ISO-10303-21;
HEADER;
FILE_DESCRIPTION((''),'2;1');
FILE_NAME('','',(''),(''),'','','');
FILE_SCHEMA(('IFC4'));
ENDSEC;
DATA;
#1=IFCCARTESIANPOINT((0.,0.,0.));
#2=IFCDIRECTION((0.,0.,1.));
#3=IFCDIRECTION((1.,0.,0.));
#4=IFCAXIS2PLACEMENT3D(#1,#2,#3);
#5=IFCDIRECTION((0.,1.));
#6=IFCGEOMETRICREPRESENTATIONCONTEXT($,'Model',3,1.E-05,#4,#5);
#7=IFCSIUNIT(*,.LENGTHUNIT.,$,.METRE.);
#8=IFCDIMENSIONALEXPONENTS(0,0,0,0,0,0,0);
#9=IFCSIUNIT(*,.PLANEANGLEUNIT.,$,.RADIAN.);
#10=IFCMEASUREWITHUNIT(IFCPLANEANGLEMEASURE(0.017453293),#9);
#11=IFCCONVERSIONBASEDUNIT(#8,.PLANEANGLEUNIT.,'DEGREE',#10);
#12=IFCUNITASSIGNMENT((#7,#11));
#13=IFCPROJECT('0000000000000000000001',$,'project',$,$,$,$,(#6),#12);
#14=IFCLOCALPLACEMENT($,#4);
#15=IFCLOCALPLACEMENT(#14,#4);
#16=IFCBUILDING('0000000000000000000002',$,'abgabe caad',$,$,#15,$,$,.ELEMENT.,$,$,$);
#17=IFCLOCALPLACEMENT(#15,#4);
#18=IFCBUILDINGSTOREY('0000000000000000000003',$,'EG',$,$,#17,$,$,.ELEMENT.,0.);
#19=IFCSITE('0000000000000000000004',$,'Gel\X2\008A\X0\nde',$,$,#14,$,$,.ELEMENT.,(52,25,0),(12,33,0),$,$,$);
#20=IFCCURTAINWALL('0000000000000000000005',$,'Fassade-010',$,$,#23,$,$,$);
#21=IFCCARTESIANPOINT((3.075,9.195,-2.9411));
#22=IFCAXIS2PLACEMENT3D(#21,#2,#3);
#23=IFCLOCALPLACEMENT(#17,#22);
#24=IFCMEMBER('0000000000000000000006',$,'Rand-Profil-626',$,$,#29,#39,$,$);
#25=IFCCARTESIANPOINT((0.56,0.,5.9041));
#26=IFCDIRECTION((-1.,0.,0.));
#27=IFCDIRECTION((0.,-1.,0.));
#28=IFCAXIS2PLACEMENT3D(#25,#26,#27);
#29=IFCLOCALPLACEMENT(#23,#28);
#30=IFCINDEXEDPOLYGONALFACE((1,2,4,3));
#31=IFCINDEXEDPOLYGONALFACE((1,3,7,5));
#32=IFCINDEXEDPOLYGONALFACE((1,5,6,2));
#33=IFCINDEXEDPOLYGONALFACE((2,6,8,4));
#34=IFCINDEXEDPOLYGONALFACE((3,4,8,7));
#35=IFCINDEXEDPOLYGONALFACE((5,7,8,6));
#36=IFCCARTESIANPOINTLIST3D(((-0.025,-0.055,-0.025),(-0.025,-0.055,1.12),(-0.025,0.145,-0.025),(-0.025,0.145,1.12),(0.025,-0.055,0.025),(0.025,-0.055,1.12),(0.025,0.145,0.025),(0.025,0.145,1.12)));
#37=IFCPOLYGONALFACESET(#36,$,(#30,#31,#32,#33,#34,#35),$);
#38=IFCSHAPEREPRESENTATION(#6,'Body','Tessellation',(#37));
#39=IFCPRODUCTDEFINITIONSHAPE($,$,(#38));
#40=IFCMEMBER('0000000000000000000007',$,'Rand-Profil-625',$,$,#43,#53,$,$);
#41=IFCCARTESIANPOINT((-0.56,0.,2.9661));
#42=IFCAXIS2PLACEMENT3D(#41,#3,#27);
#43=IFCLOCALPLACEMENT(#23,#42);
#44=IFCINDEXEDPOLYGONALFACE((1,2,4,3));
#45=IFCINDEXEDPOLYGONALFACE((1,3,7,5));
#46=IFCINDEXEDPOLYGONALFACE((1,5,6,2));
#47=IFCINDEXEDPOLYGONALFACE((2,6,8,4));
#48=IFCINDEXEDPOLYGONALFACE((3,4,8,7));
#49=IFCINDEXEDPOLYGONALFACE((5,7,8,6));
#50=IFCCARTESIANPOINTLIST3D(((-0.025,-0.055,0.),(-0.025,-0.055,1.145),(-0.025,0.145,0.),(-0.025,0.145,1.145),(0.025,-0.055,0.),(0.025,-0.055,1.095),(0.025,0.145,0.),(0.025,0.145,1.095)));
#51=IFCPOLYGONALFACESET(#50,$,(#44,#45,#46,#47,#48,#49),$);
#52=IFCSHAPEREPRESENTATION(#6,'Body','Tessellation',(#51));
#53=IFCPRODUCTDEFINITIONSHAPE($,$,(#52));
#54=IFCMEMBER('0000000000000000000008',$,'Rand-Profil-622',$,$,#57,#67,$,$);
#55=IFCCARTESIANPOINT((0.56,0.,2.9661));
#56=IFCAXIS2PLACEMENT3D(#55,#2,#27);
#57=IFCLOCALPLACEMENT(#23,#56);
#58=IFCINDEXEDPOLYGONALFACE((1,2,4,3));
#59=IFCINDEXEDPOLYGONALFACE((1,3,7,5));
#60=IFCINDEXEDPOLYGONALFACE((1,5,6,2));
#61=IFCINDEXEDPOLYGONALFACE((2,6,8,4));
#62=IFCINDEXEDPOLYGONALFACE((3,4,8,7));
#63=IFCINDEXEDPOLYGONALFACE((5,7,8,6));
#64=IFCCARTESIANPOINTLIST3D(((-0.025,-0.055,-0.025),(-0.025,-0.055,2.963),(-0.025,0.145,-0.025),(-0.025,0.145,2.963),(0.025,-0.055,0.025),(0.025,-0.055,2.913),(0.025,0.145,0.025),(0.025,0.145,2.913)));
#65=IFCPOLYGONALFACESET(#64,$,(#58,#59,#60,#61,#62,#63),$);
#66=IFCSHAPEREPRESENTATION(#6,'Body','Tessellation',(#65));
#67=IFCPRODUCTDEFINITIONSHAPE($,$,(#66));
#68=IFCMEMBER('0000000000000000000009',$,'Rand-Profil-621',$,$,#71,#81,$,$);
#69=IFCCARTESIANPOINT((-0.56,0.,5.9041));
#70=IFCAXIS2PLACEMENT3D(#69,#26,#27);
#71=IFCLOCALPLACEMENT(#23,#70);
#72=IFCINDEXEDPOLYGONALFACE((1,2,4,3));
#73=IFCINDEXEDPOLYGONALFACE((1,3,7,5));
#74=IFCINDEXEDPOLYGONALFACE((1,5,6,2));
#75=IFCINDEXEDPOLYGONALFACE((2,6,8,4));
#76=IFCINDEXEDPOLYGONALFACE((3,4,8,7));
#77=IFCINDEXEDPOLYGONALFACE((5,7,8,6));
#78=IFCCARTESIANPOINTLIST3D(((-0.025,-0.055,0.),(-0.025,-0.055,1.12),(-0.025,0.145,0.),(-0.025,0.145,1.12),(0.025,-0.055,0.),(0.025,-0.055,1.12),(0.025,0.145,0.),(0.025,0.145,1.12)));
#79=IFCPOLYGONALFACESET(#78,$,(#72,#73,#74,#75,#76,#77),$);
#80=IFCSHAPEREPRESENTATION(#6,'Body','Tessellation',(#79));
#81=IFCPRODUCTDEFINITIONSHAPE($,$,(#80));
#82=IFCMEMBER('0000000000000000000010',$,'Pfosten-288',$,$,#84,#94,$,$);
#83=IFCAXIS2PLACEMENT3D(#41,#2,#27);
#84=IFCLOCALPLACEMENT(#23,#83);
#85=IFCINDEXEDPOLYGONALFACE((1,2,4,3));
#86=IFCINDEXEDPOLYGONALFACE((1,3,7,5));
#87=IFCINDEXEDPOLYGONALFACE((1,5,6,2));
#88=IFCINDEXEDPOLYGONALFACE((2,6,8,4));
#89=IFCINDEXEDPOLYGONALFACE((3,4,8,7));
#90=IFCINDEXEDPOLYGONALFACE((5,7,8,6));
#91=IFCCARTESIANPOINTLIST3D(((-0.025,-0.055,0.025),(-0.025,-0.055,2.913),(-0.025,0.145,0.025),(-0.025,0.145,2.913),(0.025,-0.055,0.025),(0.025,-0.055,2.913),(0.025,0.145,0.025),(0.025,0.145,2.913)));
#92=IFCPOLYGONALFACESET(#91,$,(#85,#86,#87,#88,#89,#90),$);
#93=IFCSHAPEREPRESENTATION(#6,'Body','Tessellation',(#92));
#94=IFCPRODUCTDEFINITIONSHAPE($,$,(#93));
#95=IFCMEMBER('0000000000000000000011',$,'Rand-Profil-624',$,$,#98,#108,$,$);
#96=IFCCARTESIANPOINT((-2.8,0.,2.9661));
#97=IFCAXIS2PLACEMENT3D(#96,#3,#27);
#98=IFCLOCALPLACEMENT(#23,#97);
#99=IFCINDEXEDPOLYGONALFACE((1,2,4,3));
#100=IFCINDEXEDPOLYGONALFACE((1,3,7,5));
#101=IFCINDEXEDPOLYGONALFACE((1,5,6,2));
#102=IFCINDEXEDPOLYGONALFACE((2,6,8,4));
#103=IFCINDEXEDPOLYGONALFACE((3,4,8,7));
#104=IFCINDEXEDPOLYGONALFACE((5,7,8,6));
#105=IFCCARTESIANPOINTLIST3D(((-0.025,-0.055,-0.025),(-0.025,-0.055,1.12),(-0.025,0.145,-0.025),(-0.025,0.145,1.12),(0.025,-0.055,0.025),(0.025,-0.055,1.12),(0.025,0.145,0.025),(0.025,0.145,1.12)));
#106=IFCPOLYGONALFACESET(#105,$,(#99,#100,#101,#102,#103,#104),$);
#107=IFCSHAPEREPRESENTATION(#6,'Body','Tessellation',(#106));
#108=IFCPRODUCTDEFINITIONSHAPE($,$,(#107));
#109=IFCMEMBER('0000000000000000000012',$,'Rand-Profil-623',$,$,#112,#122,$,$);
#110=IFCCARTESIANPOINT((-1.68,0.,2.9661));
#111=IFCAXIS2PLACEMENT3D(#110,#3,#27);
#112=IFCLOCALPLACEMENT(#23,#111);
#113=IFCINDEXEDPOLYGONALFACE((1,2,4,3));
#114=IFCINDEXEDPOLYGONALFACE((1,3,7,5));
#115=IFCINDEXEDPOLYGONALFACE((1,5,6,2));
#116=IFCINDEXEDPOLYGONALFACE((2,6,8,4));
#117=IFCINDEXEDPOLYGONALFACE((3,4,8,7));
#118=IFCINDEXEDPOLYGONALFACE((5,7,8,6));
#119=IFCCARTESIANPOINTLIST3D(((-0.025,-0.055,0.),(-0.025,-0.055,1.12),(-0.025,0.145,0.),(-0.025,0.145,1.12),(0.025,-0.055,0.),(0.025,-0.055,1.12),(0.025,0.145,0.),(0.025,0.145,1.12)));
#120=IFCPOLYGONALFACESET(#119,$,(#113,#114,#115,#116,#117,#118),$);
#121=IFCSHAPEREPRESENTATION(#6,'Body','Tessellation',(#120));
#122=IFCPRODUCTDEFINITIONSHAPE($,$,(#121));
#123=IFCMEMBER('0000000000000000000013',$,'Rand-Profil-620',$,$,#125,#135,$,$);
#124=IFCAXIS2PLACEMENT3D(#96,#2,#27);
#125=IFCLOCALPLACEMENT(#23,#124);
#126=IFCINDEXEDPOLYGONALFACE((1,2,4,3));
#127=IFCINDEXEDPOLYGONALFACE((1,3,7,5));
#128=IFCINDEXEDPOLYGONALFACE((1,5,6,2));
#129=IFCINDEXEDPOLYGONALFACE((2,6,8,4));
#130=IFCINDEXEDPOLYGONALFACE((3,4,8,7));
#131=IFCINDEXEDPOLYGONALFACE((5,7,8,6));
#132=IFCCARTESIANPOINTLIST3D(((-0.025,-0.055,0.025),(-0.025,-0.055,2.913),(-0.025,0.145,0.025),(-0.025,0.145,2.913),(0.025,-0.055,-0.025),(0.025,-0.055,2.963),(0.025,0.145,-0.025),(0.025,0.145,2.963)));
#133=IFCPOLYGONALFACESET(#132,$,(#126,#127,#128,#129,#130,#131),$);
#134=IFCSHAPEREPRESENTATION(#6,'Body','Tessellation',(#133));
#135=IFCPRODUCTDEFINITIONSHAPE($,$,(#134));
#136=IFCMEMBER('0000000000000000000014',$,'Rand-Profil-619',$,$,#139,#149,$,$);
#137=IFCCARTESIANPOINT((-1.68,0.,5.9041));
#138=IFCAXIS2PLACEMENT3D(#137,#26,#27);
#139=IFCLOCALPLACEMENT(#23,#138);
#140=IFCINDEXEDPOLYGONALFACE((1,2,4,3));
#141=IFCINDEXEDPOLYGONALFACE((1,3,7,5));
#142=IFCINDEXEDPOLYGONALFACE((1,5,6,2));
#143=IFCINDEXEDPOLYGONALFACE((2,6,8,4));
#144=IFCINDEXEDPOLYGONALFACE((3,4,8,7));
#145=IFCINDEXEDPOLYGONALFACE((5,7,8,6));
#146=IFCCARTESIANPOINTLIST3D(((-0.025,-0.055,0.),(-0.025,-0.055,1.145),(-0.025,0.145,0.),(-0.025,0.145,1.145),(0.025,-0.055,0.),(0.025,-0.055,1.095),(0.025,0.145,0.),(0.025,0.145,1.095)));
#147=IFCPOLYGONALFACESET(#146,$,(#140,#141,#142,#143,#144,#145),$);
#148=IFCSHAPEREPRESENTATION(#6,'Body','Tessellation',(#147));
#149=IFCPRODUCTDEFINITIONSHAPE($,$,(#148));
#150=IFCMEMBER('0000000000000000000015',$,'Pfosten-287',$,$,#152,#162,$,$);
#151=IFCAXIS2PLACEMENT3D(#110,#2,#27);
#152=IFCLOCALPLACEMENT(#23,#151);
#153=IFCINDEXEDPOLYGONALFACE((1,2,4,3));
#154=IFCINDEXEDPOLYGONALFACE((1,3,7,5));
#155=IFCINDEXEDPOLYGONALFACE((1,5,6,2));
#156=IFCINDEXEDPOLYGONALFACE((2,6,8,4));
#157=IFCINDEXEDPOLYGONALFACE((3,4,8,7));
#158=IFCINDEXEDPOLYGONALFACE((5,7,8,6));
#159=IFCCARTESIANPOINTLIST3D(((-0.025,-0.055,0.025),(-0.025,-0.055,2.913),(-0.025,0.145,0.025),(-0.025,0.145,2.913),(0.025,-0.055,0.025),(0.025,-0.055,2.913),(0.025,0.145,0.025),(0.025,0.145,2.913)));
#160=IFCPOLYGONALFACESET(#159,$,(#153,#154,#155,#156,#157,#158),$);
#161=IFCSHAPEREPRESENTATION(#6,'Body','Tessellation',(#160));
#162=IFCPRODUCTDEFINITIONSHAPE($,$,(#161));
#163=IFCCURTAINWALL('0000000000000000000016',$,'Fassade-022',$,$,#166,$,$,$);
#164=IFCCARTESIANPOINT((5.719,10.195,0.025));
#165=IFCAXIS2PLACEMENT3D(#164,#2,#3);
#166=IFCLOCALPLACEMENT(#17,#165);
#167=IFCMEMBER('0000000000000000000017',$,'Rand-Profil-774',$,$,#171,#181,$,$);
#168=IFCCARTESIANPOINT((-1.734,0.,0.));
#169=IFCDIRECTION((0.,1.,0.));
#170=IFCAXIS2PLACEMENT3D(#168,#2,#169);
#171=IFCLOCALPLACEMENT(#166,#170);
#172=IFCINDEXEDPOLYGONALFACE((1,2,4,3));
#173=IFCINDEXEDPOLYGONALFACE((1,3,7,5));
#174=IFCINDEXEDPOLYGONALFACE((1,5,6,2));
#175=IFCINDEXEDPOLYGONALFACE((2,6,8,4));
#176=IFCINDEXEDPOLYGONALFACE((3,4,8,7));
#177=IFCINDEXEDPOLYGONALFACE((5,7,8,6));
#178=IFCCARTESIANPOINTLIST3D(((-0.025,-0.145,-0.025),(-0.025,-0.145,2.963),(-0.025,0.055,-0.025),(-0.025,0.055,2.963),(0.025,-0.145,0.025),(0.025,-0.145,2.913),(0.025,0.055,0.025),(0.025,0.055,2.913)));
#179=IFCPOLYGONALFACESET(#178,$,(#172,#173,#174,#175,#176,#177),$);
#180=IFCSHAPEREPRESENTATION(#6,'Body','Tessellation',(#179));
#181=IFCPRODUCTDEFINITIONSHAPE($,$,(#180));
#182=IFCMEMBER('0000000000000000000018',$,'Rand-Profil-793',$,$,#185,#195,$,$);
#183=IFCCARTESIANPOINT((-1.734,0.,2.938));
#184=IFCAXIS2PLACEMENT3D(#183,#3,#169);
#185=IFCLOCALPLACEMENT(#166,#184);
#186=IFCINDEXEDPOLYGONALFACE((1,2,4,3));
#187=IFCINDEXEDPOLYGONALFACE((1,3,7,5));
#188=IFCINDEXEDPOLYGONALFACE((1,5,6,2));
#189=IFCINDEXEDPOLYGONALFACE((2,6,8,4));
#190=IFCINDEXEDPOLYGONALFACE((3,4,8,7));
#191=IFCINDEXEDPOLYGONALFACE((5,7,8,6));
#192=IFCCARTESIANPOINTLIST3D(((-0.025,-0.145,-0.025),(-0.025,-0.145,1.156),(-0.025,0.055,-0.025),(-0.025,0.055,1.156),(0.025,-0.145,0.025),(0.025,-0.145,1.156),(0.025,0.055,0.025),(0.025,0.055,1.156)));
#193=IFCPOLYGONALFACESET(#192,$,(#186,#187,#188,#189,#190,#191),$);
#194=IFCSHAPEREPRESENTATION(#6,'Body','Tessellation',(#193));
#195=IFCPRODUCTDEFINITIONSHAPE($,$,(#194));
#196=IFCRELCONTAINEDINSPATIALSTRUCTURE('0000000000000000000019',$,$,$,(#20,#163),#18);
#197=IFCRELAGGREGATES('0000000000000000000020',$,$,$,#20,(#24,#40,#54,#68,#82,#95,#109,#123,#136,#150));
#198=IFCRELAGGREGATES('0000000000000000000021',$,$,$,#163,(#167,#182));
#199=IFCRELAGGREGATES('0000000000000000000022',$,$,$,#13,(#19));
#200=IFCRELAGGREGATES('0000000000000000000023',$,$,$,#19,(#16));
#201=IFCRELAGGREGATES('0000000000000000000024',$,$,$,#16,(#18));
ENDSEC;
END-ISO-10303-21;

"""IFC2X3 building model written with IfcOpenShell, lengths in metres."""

from ifc_helpers import new_model, entity, si_unit, converted_unit, direction, frame, origin_with_axes, place, context, project, spatial, polyline, outline, extrude, clip, halfspace, element, aggregate, save


model = new_model("IFC2X3")

# Units and contexts
model_context = context("Model", 3, precision=1e-05, world=origin_with_axes(), true_north=direction((0.0, 1.0)))
ifc_project = project(units=[si_unit("LENGTHUNIT", "METRE"), converted_unit("PLANEANGLEUNIT", "DEGREE", entity("IfcPlaneAngleMeasure", 0.017453293), si_unit("PLANEANGLEUNIT", "RADIAN"), dimensions=[0, 0, 0, 0, 0, 0, 0])], contexts=[model_context])

# Site, building, storey
site_placement = place(None, origin_with_axes())
site = spatial("IfcSite", under=ifc_project, at=site_placement, Name="Gel\u008ande", CompositionType="ELEMENT", RefLatitude=(52, 25, 0), RefLongitude=(12, 33, 0))
building_placement = place(site_placement, origin_with_axes())
building = spatial("IfcBuilding", under=site, at=building_placement, Name="abgabe caad", CompositionType="ELEMENT")
storey_placement = place(building_placement, origin_with_axes())
storey = spatial("IfcBuildingStorey", under=building, at=storey_placement, Name="EG", CompositionType="ELEMENT", Elevation=0.0)

# Curtain walls, members
curtain_wall_1_placement = place(storey_placement, frame((3.075, 9.195, -2.9411), z_axis=(0.0, 0.0, 1.0), x_axis=(1.0, 0.0, 0.0)))
curtain_wall_1 = element("IfcCurtainWall", 1, at=curtain_wall_1_placement, inside=storey, Name="Fassade-010")
member_1_placement = place(curtain_wall_1_placement, frame((0.56, 0.0, 5.9041), z_axis=(-1.0, 0.0, 0.0), x_axis=(0.0, -1.0, 0.0)))
member_1 = element("IfcMember", 2, at=member_1_placement, Name="Rand-Profil-626", context=model_context, shape_type="Clipping", body=[
    clip(extrude(outline(polyline([(-0.025, -0.145), (0.025, -0.145), (0.025, 0.055), (-0.025, 0.055), (-0.025, -0.145)])), frame((0.0, 0.0, -0.025), z_axis=(0.0, 0.0, 1.0), x_axis=(-1.0, 0.0, 0.0)), (0.0, 0.0, 1.0), 1.145), halfspace(frame((0.0, 0.0, 0.0), z_axis=(-0.707107, 0.0, 0.707107), x_axis=(-0.707107, 0.0, -0.707107)), True)),
])
member_2_placement = place(curtain_wall_1_placement, frame((-0.56, 0.0, 2.9661), z_axis=(1.0, 0.0, 0.0), x_axis=(0.0, -1.0, 0.0)))
member_2 = element("IfcMember", 3, at=member_2_placement, Name="Rand-Profil-625", context=model_context, shape_type="Clipping", body=[
    clip(extrude(outline(polyline([(0.025, 0.145), (-0.025, 0.145), (-0.025, -0.055), (0.025, -0.055), (0.025, 0.145)])), origin_with_axes(), (0.0, 0.0, 1.0), 1.145), halfspace(frame((0.56, 0.0, 0.56), z_axis=(-0.707107, 0.0, -0.707107), x_axis=(0.707107, 0.0, -0.707107)), True)),
])
member_3_placement = place(curtain_wall_1_placement, frame((0.56, 0.0, 2.9661), z_axis=(0.0, 0.0, 1.0), x_axis=(0.0, -1.0, 0.0)))
member_3 = element("IfcMember", 4, at=member_3_placement, Name="Rand-Profil-622", context=model_context, shape_type="Clipping", body=[
    clip(clip(extrude(outline(polyline([(0.145, -0.025), (0.145, 0.025), (-0.055, 0.025), (-0.055, -0.025), (0.145, -0.025)])), frame((0.0, 0.0, -0.025), z_axis=(0.0, 0.0, 1.0), x_axis=(0.0, 1.0, 0.0)), (0.0, 0.0, 1.0), 2.988), halfspace(frame((0.0, 0.0, 0.0), z_axis=(-0.707107, 0.0, 0.707107), x_axis=(-0.707107, 0.0, -0.707107)), True)), halfspace(frame((1.469, 0.0, 1.469), z_axis=(-0.707107, 0.0, -0.707107), x_axis=(0.707107, 0.0, -0.707107)), True)),
])
member_4_placement = place(curtain_wall_1_placement, frame((-0.56, 0.0, 5.9041), z_axis=(-1.0, 0.0, 0.0), x_axis=(0.0, -1.0, 0.0)))
member_4 = element("IfcMember", 5, at=member_4_placement, Name="Rand-Profil-621", context=model_context, shape_type="SweptSolid", body=[
    extrude(outline(polyline([(-0.025, -0.145), (0.025, -0.145), (0.025, 0.055), (-0.025, 0.055), (-0.025, -0.145)])), frame((0.0, 0.0, 0.0), z_axis=(0.0, 0.0, 1.0), x_axis=(-1.0, 0.0, 0.0)), (0.0, 0.0, 1.0), 1.12),
])
member_5_placement = place(curtain_wall_1_placement, frame((-0.56, 0.0, 2.9661), z_axis=(0.0, 0.0, 1.0), x_axis=(0.0, -1.0, 0.0)))
member_5 = element("IfcMember", 6, at=member_5_placement, Name="Pfosten-288", context=model_context, shape_type="SweptSolid", body=[
    extrude(outline(polyline([(0.145, -0.025), (0.145, 0.025), (-0.055, 0.025), (-0.055, -0.025), (0.145, -0.025)])), frame((0.0, 0.0, 0.025), z_axis=(0.0, 0.0, 1.0), x_axis=(0.0, 1.0, 0.0)), (0.0, 0.0, 1.0), 2.888),
])
member_6_placement = place(curtain_wall_1_placement, frame((-2.8, 0.0, 2.9661), z_axis=(1.0, 0.0, 0.0), x_axis=(0.0, -1.0, 0.0)))
member_6 = element("IfcMember", 7, at=member_6_placement, Name="Rand-Profil-624", context=model_context, shape_type="Clipping", body=[
    clip(extrude(outline(polyline([(0.025, 0.145), (-0.025, 0.145), (-0.025, -0.055), (0.025, -0.055), (0.025, 0.145)])), frame((0.0, 0.0, -0.025), z_axis=(0.0, 0.0, 1.0), x_axis=(1.0, 0.0, 0.0)), (0.0, 0.0, 1.0), 1.145), halfspace(frame((0.0, 0.0, 0.0), z_axis=(-0.707107, 0.0, 0.707107), x_axis=(-0.707107, 0.0, -0.707107)), True)),
])
member_7_placement = place(curtain_wall_1_placement, frame((-1.68, 0.0, 2.9661), z_axis=(1.0, 0.0, 0.0), x_axis=(0.0, -1.0, 0.0)))
member_7 = element("IfcMember", 8, at=member_7_placement, Name="Rand-Profil-623", context=model_context, shape_type="SweptSolid", body=[
    extrude(outline(polyline([(0.025, 0.145), (-0.025, 0.145), (-0.025, -0.055), (0.025, -0.055), (0.025, 0.145)])), origin_with_axes(), (0.0, 0.0, 1.0), 1.12),
])
member_8_placement = place(curtain_wall_1_placement, frame((-2.8, 0.0, 2.9661), z_axis=(0.0, 0.0, 1.0), x_axis=(0.0, -1.0, 0.0)))
member_8 = element("IfcMember", 9, at=member_8_placement, Name="Rand-Profil-620", context=model_context, shape_type="Clipping", body=[
    clip(clip(extrude(outline(polyline([(0.145, -0.025), (0.145, 0.025), (-0.055, 0.025), (-0.055, -0.025), (0.145, -0.025)])), frame((0.0, 0.0, -0.025), z_axis=(0.0, 0.0, 1.0), x_axis=(0.0, 1.0, 0.0)), (0.0, 0.0, 1.0), 2.988), halfspace(frame((0.0, 0.0, 0.0), z_axis=(0.707107, 0.0, 0.707107), x_axis=(-0.707107, 0.0, 0.707107)), True)), halfspace(frame((-1.469, 0.0, 1.469), z_axis=(0.707107, 0.0, -0.707107), x_axis=(0.707107, 0.0, 0.707107)), True)),
])
member_9_placement = place(curtain_wall_1_placement, frame((-1.68, 0.0, 5.9041), z_axis=(-1.0, 0.0, 0.0), x_axis=(0.0, -1.0, 0.0)))
member_9 = element("IfcMember", 10, at=member_9_placement, Name="Rand-Profil-619", context=model_context, shape_type="Clipping", body=[
    clip(extrude(outline(polyline([(-0.025, -0.145), (0.025, -0.145), (0.025, 0.055), (-0.025, 0.055), (-0.025, -0.145)])), frame((0.0, 0.0, 0.0), z_axis=(0.0, 0.0, 1.0), x_axis=(-1.0, 0.0, 0.0)), (0.0, 0.0, 1.0), 1.145), halfspace(frame((0.56, 0.0, 0.56), z_axis=(-0.707107, 0.0, -0.707107), x_axis=(0.707107, 0.0, -0.707107)), True)),
])
member_10_placement = place(curtain_wall_1_placement, frame((-1.68, 0.0, 2.9661), z_axis=(0.0, 0.0, 1.0), x_axis=(0.0, -1.0, 0.0)))
member_10 = element("IfcMember", 11, at=member_10_placement, Name="Pfosten-287", context=model_context, shape_type="SweptSolid", body=[
    extrude(outline(polyline([(0.145, -0.025), (0.145, 0.025), (-0.055, 0.025), (-0.055, -0.025), (0.145, -0.025)])), frame((0.0, 0.0, 0.025), z_axis=(0.0, 0.0, 1.0), x_axis=(0.0, 1.0, 0.0)), (0.0, 0.0, 1.0), 2.888),
])
curtain_wall_2_placement = place(storey_placement, frame((5.719, 10.195, 0.025), z_axis=(0.0, 0.0, 1.0), x_axis=(1.0, 0.0, 0.0)))
curtain_wall_2 = element("IfcCurtainWall", 12, at=curtain_wall_2_placement, inside=storey, Name="Fassade-022")
member_11_placement = place(curtain_wall_2_placement, frame((-1.734, 0.0, 0.0), z_axis=(0.0, 0.0, 1.0), x_axis=(0.0, 1.0, 0.0)))
member_11 = element("IfcMember", 13, at=member_11_placement, Name="Rand-Profil-774", context=model_context, shape_type="Clipping", body=[
    clip(clip(extrude(outline(polyline([(0.145, 0.025), (-0.055, 0.025), (-0.055, -0.025), (0.145, -0.025), (0.145, 0.025)])), frame((0.0, 0.0, -0.025), z_axis=(0.0, 0.0, 1.0), x_axis=(0.0, -1.0, 0.0)), (0.0, 0.0, 1.0), 2.988), halfspace(frame((0.0, 0.0, 0.0), z_axis=(-0.707107, 0.0, 0.707107), x_axis=(-0.707107, 0.0, -0.707107)), True)), halfspace(frame((1.469, 0.0, 1.469), z_axis=(-0.707107, 0.0, -0.707107), x_axis=(0.707107, 0.0, -0.707107)), True)),
])
member_12_placement = place(curtain_wall_2_placement, frame((-1.734, 0.0, 2.938), z_axis=(1.0, 0.0, 0.0), x_axis=(0.0, 1.0, 0.0)))
member_12 = element("IfcMember", 14, at=member_12_placement, Name="Rand-Profil-793", context=model_context, shape_type="Clipping", body=[
    clip(extrude(outline(polyline([(-0.025, 0.145), (-0.025, -0.055), (0.025, -0.055), (0.025, 0.145), (-0.025, 0.145)])), frame((0.0, 0.0, -0.025), z_axis=(0.0, 0.0, 1.0), x_axis=(-1.0, 0.0, 0.0)), (0.0, 0.0, 1.0), 1.181), halfspace(frame((0.0, 0.0, 0.0), z_axis=(-0.707107, 0.0, 0.707107), x_axis=(-0.707107, 0.0, -0.707107)), True)),
])

aggregate(curtain_wall_1, [member_1, member_2, member_3, member_4, member_5, member_6, member_7, member_8, member_9, member_10])
aggregate(curtain_wall_2, [member_11, member_12])

save(model, "model.ifc")
